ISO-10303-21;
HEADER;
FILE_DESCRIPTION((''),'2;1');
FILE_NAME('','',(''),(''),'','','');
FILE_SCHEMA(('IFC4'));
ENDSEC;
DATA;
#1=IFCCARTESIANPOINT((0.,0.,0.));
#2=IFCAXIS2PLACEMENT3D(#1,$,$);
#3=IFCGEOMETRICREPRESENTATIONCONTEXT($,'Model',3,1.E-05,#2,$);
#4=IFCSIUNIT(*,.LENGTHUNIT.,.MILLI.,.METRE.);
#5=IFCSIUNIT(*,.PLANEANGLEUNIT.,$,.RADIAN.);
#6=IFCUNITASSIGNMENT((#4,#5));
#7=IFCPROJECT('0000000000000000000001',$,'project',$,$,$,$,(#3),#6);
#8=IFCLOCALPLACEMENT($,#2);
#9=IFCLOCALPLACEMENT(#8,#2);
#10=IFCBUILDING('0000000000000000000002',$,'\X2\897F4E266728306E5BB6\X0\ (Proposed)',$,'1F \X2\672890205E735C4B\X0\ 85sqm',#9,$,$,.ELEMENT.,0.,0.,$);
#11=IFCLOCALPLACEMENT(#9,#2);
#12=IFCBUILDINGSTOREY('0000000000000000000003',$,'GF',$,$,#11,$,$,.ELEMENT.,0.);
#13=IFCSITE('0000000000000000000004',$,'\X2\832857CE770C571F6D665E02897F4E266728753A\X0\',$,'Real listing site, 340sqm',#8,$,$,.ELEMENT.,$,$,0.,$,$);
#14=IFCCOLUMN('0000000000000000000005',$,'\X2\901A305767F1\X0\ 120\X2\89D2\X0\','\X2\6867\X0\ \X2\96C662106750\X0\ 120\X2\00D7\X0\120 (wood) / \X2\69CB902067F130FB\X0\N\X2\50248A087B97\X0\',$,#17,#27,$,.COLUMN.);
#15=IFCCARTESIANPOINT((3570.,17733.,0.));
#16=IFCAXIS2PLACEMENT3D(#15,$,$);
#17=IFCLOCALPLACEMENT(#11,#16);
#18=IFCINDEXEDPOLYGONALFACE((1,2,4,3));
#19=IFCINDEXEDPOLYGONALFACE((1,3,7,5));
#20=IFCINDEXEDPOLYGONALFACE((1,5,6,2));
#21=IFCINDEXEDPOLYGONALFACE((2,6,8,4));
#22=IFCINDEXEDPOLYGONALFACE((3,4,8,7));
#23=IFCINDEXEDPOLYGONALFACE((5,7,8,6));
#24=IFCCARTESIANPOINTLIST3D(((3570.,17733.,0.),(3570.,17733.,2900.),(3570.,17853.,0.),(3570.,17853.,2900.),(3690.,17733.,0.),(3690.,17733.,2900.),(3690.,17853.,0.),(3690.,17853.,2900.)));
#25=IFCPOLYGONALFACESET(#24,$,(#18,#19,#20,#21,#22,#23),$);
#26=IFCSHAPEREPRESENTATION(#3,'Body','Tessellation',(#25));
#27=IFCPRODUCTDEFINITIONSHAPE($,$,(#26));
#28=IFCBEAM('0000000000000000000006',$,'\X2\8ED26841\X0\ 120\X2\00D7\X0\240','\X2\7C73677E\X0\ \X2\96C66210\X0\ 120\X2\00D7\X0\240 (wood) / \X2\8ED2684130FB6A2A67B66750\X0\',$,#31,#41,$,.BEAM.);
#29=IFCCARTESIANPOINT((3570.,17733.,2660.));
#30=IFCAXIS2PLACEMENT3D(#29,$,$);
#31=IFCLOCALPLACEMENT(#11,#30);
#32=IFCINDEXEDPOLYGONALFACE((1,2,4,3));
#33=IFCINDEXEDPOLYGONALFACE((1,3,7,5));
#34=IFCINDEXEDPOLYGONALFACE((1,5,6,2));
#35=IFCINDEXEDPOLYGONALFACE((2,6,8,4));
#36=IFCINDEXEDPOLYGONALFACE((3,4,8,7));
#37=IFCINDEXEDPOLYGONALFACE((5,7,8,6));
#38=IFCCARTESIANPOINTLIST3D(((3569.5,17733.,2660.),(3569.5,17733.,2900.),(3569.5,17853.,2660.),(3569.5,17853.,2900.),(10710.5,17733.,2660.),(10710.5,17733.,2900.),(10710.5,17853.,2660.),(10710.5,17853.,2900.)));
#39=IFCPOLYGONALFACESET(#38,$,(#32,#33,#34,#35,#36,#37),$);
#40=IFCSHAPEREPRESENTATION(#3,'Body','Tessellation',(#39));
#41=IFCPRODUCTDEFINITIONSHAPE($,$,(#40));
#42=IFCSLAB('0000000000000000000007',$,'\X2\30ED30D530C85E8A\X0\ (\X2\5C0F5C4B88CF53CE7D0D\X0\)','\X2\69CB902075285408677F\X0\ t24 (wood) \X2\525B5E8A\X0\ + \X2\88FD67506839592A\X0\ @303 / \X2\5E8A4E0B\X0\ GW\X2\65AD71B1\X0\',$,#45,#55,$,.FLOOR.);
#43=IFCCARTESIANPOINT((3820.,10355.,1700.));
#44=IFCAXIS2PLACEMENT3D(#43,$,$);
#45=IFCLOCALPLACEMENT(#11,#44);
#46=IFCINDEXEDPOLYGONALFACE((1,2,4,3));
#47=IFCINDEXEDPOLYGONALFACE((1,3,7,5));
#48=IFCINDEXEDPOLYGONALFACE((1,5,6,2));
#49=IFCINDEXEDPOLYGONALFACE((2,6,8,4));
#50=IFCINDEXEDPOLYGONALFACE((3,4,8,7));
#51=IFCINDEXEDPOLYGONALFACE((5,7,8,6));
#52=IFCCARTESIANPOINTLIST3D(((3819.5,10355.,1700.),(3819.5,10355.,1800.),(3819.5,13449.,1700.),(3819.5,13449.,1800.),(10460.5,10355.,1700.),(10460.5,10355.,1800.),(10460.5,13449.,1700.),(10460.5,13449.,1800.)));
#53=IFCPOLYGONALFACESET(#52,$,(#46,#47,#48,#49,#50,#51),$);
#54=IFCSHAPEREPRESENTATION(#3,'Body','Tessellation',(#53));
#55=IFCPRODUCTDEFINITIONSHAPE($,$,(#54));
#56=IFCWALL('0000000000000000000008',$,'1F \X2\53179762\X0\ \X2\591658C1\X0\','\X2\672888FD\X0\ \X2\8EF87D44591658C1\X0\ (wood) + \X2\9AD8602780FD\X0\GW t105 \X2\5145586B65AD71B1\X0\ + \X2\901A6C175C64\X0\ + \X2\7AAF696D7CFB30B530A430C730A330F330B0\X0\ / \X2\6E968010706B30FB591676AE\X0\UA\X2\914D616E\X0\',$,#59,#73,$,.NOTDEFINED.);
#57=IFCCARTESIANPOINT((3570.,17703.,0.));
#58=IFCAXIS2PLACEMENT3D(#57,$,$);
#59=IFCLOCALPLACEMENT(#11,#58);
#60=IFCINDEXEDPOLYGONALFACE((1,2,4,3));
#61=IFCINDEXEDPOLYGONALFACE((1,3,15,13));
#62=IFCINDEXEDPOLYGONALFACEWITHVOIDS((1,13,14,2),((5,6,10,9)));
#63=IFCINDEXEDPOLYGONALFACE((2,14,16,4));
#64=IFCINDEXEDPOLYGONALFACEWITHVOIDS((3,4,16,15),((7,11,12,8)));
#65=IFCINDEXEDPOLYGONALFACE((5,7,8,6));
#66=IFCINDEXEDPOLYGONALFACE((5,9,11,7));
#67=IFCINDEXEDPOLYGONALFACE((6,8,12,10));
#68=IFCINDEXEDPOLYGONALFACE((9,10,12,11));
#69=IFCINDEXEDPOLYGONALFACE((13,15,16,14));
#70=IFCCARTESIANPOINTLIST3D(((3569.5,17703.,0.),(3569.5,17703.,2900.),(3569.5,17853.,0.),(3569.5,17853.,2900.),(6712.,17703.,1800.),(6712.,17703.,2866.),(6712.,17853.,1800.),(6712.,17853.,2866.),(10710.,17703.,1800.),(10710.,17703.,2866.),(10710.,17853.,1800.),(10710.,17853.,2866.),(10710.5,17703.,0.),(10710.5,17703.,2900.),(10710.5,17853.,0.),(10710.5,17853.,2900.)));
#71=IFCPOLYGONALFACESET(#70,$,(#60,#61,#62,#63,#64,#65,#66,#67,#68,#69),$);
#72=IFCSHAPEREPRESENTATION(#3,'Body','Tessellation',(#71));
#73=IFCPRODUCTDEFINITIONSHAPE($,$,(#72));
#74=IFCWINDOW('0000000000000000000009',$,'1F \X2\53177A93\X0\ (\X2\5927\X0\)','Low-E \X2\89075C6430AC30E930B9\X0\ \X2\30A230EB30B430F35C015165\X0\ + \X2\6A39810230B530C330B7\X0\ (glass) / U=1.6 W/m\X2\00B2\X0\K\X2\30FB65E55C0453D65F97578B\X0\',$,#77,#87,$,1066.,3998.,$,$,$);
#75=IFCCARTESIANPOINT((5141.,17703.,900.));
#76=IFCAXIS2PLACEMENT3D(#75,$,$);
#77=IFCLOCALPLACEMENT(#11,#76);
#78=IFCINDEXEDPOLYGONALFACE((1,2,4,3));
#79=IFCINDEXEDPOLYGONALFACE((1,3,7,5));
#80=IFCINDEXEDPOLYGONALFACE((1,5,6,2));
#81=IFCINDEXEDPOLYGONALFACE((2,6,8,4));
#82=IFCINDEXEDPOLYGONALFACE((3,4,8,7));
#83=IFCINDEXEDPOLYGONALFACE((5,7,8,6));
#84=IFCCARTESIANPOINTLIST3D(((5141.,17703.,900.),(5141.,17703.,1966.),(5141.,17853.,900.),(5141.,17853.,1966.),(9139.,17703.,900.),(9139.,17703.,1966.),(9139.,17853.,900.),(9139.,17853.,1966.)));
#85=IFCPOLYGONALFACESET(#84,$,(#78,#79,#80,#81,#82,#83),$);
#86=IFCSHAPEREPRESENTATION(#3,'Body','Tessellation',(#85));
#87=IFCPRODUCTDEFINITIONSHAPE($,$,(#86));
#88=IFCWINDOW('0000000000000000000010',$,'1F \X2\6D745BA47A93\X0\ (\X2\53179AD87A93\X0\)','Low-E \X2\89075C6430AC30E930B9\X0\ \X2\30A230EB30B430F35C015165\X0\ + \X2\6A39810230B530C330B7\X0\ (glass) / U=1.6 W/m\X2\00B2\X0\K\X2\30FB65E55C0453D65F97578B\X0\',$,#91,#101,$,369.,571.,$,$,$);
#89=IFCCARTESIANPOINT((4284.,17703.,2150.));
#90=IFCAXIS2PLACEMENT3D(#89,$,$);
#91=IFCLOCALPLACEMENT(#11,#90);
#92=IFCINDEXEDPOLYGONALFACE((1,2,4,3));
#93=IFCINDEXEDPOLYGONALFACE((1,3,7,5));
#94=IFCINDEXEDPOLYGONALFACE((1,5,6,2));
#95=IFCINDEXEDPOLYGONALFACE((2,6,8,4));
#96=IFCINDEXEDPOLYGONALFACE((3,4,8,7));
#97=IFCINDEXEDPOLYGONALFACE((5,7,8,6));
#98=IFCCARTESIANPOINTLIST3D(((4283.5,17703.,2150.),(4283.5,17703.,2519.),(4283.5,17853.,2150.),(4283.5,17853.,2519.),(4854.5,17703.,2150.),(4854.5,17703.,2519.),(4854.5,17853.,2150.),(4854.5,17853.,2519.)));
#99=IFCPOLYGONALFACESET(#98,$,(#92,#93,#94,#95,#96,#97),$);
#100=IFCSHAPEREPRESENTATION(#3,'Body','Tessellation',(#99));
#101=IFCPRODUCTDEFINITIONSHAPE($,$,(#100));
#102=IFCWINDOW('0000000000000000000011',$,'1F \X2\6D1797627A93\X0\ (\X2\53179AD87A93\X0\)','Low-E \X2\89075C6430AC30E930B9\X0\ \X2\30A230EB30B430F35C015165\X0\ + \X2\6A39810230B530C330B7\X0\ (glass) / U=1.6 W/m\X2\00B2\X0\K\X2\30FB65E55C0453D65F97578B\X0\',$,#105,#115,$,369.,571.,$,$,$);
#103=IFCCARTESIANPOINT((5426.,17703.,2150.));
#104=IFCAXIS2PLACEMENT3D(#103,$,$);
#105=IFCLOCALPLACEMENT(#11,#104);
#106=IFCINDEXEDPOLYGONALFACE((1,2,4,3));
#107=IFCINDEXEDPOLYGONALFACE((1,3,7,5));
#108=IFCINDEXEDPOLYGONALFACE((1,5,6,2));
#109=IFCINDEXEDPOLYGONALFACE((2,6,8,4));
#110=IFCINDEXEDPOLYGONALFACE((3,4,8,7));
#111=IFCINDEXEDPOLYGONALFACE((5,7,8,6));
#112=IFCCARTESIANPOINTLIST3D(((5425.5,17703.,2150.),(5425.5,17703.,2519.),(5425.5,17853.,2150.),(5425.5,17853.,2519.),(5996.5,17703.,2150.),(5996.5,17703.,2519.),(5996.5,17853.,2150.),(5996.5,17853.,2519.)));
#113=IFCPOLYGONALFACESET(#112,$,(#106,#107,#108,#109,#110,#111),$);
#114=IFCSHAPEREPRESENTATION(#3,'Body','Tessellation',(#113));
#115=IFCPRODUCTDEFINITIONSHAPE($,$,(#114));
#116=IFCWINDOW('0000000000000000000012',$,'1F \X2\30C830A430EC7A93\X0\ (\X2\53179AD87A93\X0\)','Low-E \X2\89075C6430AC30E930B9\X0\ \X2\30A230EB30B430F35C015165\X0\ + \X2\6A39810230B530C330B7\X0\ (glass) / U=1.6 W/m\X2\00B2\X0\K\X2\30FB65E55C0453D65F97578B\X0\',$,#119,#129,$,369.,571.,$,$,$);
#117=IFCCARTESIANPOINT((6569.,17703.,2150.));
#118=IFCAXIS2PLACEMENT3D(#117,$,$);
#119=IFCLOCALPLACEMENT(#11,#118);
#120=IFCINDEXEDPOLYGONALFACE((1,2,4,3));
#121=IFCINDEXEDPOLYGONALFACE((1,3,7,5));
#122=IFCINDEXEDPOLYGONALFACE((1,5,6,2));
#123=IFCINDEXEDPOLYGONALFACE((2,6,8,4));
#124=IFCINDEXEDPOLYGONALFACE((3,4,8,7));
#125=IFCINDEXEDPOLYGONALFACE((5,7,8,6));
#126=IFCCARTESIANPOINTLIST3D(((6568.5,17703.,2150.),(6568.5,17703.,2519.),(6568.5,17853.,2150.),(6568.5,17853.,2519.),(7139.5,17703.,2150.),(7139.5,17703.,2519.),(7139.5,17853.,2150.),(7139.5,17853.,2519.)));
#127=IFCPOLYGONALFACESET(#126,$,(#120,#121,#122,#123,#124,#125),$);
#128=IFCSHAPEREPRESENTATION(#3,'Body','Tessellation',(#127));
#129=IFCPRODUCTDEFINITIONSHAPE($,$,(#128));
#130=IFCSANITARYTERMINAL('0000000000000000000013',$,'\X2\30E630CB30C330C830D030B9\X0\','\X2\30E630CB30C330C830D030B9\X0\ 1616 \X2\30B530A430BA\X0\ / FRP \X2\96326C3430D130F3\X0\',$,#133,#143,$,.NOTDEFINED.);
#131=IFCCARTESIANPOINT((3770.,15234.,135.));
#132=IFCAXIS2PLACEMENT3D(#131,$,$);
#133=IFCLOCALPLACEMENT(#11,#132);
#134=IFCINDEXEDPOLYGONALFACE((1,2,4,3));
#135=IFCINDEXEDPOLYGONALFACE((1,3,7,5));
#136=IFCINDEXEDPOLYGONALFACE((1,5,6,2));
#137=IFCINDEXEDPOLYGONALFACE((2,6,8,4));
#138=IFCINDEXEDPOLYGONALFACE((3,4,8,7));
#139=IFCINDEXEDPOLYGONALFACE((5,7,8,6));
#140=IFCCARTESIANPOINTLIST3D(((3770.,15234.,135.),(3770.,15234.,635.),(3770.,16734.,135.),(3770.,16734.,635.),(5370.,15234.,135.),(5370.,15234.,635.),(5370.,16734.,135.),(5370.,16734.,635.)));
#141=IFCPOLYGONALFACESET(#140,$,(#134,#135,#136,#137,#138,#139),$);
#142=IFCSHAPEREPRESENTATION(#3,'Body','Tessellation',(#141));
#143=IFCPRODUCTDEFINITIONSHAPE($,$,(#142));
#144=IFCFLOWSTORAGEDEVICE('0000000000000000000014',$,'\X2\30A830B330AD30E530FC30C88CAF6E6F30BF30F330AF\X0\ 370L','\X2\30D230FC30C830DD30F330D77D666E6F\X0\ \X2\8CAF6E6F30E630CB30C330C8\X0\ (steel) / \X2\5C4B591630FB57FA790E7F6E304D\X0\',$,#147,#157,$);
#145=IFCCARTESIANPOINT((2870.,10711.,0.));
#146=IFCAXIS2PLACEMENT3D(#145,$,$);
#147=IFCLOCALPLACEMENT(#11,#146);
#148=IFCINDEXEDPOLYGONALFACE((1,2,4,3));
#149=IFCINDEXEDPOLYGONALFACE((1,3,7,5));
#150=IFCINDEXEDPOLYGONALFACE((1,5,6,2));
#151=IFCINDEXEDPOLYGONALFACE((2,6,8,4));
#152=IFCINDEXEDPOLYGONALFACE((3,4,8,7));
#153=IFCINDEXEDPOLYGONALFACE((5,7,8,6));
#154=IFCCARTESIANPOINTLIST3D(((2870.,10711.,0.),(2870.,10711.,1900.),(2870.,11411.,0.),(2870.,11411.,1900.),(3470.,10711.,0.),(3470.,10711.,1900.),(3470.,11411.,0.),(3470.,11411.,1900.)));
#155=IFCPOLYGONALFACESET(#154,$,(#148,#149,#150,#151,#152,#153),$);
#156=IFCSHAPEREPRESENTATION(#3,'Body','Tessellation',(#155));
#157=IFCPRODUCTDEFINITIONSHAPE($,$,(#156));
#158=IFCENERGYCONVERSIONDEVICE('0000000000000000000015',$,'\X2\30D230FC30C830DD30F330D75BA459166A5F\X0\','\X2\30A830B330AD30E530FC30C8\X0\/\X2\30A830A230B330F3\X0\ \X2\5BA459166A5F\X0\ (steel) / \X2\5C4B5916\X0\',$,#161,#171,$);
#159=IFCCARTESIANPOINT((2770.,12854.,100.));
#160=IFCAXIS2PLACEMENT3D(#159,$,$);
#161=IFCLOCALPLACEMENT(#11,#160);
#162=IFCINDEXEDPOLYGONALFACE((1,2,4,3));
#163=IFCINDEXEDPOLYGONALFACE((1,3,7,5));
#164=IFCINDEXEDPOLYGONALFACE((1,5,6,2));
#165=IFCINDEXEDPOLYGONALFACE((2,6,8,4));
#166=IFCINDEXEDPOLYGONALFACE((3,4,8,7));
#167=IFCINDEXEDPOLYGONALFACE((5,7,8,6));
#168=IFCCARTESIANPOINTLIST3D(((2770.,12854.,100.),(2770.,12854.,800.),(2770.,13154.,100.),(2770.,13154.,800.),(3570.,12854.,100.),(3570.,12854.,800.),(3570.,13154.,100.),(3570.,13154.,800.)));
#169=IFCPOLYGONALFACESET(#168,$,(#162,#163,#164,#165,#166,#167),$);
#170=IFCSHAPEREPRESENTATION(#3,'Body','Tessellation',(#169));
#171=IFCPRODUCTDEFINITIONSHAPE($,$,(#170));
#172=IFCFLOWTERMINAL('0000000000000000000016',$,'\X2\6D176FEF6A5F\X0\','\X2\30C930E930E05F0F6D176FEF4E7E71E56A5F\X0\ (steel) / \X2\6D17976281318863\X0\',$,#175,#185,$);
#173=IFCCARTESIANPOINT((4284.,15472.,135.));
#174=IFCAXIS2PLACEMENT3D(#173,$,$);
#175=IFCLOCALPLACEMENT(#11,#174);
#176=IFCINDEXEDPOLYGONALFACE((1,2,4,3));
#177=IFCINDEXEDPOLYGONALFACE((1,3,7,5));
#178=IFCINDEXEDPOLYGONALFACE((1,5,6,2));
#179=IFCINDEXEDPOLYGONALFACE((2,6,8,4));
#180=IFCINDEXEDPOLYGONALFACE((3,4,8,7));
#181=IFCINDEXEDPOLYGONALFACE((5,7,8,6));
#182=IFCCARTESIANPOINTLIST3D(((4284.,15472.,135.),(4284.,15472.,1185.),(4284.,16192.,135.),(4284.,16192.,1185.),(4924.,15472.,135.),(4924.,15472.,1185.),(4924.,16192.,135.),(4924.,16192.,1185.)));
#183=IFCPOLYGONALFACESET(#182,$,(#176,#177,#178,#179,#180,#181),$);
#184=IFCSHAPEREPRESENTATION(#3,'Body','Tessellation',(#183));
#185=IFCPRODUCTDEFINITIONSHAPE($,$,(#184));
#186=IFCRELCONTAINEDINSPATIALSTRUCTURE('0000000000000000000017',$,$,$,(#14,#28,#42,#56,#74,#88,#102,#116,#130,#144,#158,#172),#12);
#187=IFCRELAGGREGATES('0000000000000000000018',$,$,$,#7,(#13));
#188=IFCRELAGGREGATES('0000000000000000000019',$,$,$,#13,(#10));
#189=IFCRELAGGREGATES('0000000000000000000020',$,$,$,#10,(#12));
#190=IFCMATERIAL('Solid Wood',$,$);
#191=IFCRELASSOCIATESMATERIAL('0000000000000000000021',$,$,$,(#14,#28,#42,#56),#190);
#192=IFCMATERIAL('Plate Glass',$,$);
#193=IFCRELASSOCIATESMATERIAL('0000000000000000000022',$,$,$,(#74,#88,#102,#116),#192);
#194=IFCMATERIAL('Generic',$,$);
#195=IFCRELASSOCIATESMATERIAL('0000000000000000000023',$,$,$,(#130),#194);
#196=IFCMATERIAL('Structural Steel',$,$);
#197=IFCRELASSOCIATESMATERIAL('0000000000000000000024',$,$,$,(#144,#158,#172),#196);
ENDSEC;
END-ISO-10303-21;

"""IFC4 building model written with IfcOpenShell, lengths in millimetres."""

from ifc_helpers import new_model, si_unit, frame, frame_2d, origin, place, context, project, spatial, rectangle, extrude, material, element, fill, save


model = new_model("IFC4")

# Units and contexts
model_context = context("Model", 3, precision=1e-05, world=origin())
ifc_project = project(units=[si_unit("LENGTHUNIT", "METRE", prefix="MILLI"), si_unit("PLANEANGLEUNIT", "RADIAN")], contexts=[model_context])

# Site, building, storey
site_placement = place(None, origin())
site = spatial("IfcSite", under=ifc_project, at=site_placement, Name="茨城県土浦市西並木町", ObjectType="Real listing site, 340sqm", CompositionType="ELEMENT", RefElevation=0.0)
building_placement = place(site_placement, origin())
building = spatial("IfcBuilding", under=site, at=building_placement, Name="西並木の家 (Proposed)", ObjectType="1F 木造平屋 85sqm", CompositionType="ELEMENT", ElevationOfRefHeight=0.0, ElevationOfTerrain=0.0)
storey_placement = place(building_placement, origin())
storey = spatial("IfcBuildingStorey", under=building, at=storey_placement, Name="GF", CompositionType="ELEMENT", Elevation=0.0)

# Column
ifc_material_1 = material(Name="Solid Wood")
column_1_placement = place(storey_placement, frame((3570.0, 17733.0, 0.0)))
element("IfcColumn", 1, at=column_1_placement, inside=storey, material=ifc_material_1, Name="通し柱 120角", Description="桧 集成材 120×120 (wood) / 構造柱・N値計算", PredefinedType="COLUMN", context=model_context, shape_type="SweptSolid", body=[
    extrude(rectangle(XDim=120.0, YDim=120.0, at=frame_2d((60.0, 60.0))), frame((3570.0, 17733.0, 0.0)), (0.0, 0.0, 1.0), 2900.0),
])

# Beam
beam_1_placement = place(storey_placement, frame((3570.0, 17733.0, 2660.0)))
element("IfcBeam", 2, at=beam_1_placement, inside=storey, material=ifc_material_1, Name="軒桁 120×240", Description="米松 集成 120×240 (wood) / 軒桁・横架材", PredefinedType="BEAM", context=model_context, shape_type="SweptSolid", body=[
    extrude(rectangle(XDim=7141.0, YDim=120.0, at=frame_2d((3570.0, 60.0))), frame((3570.0, 17733.0, 2660.0)), (0.0, 0.0, 1.0), 240.0),
])

# Slab
slab_placement = place(storey_placement, frame((3820.0, 10355.0, 1700.0)))
element("IfcSlab", 3, at=slab_placement, inside=storey, material=ifc_material_1, Name="ロフト床 (小屋裏収納)", Description="構造用合板 t24 (wood) 剛床 + 製材根太 @303 / 床下 GW断熱", PredefinedType="FLOOR", context=model_context, shape_type="SweptSolid", body=[
    extrude(rectangle(XDim=6641.0, YDim=3094.0, at=frame_2d((3320.0, 1547.0))), frame((3820.0, 10355.0, 1700.0)), (0.0, 0.0, 1.0), 100.0),
])

# Wall, openings, windows
wall_1_placement = place(storey_placement, frame((3570.0, 17703.0, 0.0)))
wall_1 = element("IfcWall", 4, at=wall_1_placement, inside=storey, material=ifc_material_1, Name="1F 北面 外壁", Description="木製 軸組外壁 (wood) + 高性能GW t105 充填断熱 + 通気層 + 窯業系サイディング / 準耐火・外皮UA配慮", PredefinedType="NOTDEFINED", context=model_context, shape_type="SweptSolid", body=[
    extrude(rectangle(XDim=7141.0, YDim=150.0, at=frame_2d((3570.0, 75.0))), frame((3570.0, 17703.0, 0.0)), (0.0, 0.0, 1.0), 2900.0),
])
opening_1_placement = place(storey_placement, frame((5141.0, 17703.0, 900.0)))
opening_1 = element("IfcOpeningElement", 5, at=opening_1_placement, cuts=wall_1, PredefinedType="NOTDEFINED", context=model_context, shape_type="SweptSolid", body=[
    extrude(rectangle(XDim=3998.0, YDim=150.0, at=frame_2d((1999.0, 75.0))), frame((5141.0, 17703.0, 900.0)), (0.0, 0.0, 1.0), 1066.0),
])
opening_2_placement = place(storey_placement, frame((4284.0, 17703.0, 2150.0)))
opening_2 = element("IfcOpeningElement", 6, at=opening_2_placement, cuts=wall_1, PredefinedType="NOTDEFINED", context=model_context, shape_type="SweptSolid", body=[
    extrude(rectangle(XDim=571.0, YDim=150.0, at=frame_2d((285.0, 75.0))), frame((4284.0, 17703.0, 2150.0)), (0.0, 0.0, 1.0), 369.0),
])
opening_3_placement = place(storey_placement, frame((5426.0, 17703.0, 2150.0)))
opening_3 = element("IfcOpeningElement", 7, at=opening_3_placement, cuts=wall_1, PredefinedType="NOTDEFINED", context=model_context, shape_type="SweptSolid", body=[
    extrude(rectangle(XDim=571.0, YDim=150.0, at=frame_2d((285.0, 75.0))), frame((5426.0, 17703.0, 2150.0)), (0.0, 0.0, 1.0), 369.0),
])
opening_4_placement = place(storey_placement, frame((6569.0, 17703.0, 2150.0)))
opening_4 = element("IfcOpeningElement", 8, at=opening_4_placement, cuts=wall_1, PredefinedType="NOTDEFINED", context=model_context, shape_type="SweptSolid", body=[
    extrude(rectangle(XDim=571.0, YDim=150.0, at=frame_2d((285.0, 75.0))), frame((6569.0, 17703.0, 2150.0)), (0.0, 0.0, 1.0), 369.0),
])
ifc_material_2 = material(Name="Plate Glass")
window_1_placement = place(storey_placement, frame((5141.0, 17703.0, 900.0)))
window_1 = element("IfcWindow", 9, at=window_1_placement, inside=storey, material=ifc_material_2, Name="1F 北窓 (大)", Description="Low-E 複層ガラス アルゴン封入 + 樹脂サッシ (glass) / U=1.6 W/m²K・日射取得型", OverallHeight=1066.0, OverallWidth=3998.0, context=model_context, shape_type="SweptSolid", body=[
    extrude(rectangle(XDim=3998.0, YDim=150.0, at=frame_2d((1999.0, 75.0))), frame((5141.0, 17703.0, 900.0)), (0.0, 0.0, 1.0), 1066.0),
])
fill(opening_1, window_1)
window_2_placement = place(storey_placement, frame((4284.0, 17703.0, 2150.0)))
window_2 = element("IfcWindow", 10, at=window_2_placement, inside=storey, material=ifc_material_2, Name="1F 浴室窓 (北高窓)", Description="Low-E 複層ガラス アルゴン封入 + 樹脂サッシ (glass) / U=1.6 W/m²K・日射取得型", OverallHeight=369.0, OverallWidth=571.0, context=model_context, shape_type="SweptSolid", body=[
    extrude(rectangle(XDim=571.0, YDim=150.0, at=frame_2d((285.0, 75.0))), frame((4284.0, 17703.0, 2150.0)), (0.0, 0.0, 1.0), 369.0),
])
fill(opening_2, window_2)
window_3_placement = place(storey_placement, frame((5426.0, 17703.0, 2150.0)))
window_3 = element("IfcWindow", 11, at=window_3_placement, inside=storey, material=ifc_material_2, Name="1F 洗面窓 (北高窓)", Description="Low-E 複層ガラス アルゴン封入 + 樹脂サッシ (glass) / U=1.6 W/m²K・日射取得型", OverallHeight=369.0, OverallWidth=571.0, context=model_context, shape_type="SweptSolid", body=[
    extrude(rectangle(XDim=571.0, YDim=150.0, at=frame_2d((285.0, 75.0))), frame((5426.0, 17703.0, 2150.0)), (0.0, 0.0, 1.0), 369.0),
])
fill(opening_3, window_3)
window_4_placement = place(storey_placement, frame((6569.0, 17703.0, 2150.0)))
window_4 = element("IfcWindow", 12, at=window_4_placement, inside=storey, material=ifc_material_2, Name="1F トイレ窓 (北高窓)", Description="Low-E 複層ガラス アルゴン封入 + 樹脂サッシ (glass) / U=1.6 W/m²K・日射取得型", OverallHeight=369.0, OverallWidth=571.0, context=model_context, shape_type="SweptSolid", body=[
    extrude(rectangle(XDim=571.0, YDim=150.0, at=frame_2d((285.0, 75.0))), frame((6569.0, 17703.0, 2150.0)), (0.0, 0.0, 1.0), 369.0),
])
fill(opening_4, window_4)

# Sanitary terminal
ifc_material_3 = material(Name="Generic")
sanitary_terminal_placement = place(storey_placement, frame((3770.0, 15234.0, 135.0)))
element("IfcSanitaryTerminal", 13, at=sanitary_terminal_placement, inside=storey, material=ifc_material_3, Name="ユニットバス", Description="ユニットバス 1616 サイズ / FRP 防水パン", PredefinedType="NOTDEFINED", context=model_context, shape_type="SweptSolid", body=[
    extrude(rectangle(XDim=1600.0, YDim=1500.0, at=frame_2d((800.0, 750.0))), frame((3770.0, 15234.0, 135.0)), (0.0, 0.0, 1.0), 500.0),
])

# Flow storage device
ifc_material_4 = material(Name="Structural Steel")
flow_storage_device_placement = place(storey_placement, frame((2870.0, 10711.0, 0.0)))
element("IfcFlowStorageDevice", 14, at=flow_storage_device_placement, inside=storey, material=ifc_material_4, Name="エコキュート貯湯タンク 370L", Description="ヒートポンプ給湯 貯湯ユニット (steel) / 屋外・基礎置き", context=model_context, shape_type="SweptSolid", body=[
    extrude(rectangle(XDim=600.0, YDim=700.0, at=frame_2d((300.0, 350.0))), frame((2870.0, 10711.0, 0.0)), (0.0, 0.0, 1.0), 1900.0),
])

# Energy conversion device
energy_conversion_device_placement = place(storey_placement, frame((2770.0, 12854.0, 100.0)))
element("IfcEnergyConversionDevice", 15, at=energy_conversion_device_placement, inside=storey, material=ifc_material_4, Name="ヒートポンプ室外機", Description="エコキュート/エアコン 室外機 (steel) / 屋外", context=model_context, shape_type="SweptSolid", body=[
    extrude(rectangle(XDim=800.0, YDim=300.0, at=frame_2d((400.0, 150.0))), frame((2770.0, 12854.0, 100.0)), (0.0, 0.0, 1.0), 700.0),
])

# Flow terminal
flow_terminal_placement = place(storey_placement, frame((4284.0, 15472.0, 135.0)))
element("IfcFlowTerminal", 16, at=flow_terminal_placement, inside=storey, material=ifc_material_4, Name="洗濯機", Description="ドラム式洗濯乾燥機 (steel) / 洗面脱衣", context=model_context, shape_type="SweptSolid", body=[
    extrude(rectangle(XDim=640.0, YDim=720.0, at=frame_2d((320.0, 360.0))), frame((4284.0, 15472.0, 135.0)), (0.0, 0.0, 1.0), 1050.0),
])

save(model, "model.ifc")
